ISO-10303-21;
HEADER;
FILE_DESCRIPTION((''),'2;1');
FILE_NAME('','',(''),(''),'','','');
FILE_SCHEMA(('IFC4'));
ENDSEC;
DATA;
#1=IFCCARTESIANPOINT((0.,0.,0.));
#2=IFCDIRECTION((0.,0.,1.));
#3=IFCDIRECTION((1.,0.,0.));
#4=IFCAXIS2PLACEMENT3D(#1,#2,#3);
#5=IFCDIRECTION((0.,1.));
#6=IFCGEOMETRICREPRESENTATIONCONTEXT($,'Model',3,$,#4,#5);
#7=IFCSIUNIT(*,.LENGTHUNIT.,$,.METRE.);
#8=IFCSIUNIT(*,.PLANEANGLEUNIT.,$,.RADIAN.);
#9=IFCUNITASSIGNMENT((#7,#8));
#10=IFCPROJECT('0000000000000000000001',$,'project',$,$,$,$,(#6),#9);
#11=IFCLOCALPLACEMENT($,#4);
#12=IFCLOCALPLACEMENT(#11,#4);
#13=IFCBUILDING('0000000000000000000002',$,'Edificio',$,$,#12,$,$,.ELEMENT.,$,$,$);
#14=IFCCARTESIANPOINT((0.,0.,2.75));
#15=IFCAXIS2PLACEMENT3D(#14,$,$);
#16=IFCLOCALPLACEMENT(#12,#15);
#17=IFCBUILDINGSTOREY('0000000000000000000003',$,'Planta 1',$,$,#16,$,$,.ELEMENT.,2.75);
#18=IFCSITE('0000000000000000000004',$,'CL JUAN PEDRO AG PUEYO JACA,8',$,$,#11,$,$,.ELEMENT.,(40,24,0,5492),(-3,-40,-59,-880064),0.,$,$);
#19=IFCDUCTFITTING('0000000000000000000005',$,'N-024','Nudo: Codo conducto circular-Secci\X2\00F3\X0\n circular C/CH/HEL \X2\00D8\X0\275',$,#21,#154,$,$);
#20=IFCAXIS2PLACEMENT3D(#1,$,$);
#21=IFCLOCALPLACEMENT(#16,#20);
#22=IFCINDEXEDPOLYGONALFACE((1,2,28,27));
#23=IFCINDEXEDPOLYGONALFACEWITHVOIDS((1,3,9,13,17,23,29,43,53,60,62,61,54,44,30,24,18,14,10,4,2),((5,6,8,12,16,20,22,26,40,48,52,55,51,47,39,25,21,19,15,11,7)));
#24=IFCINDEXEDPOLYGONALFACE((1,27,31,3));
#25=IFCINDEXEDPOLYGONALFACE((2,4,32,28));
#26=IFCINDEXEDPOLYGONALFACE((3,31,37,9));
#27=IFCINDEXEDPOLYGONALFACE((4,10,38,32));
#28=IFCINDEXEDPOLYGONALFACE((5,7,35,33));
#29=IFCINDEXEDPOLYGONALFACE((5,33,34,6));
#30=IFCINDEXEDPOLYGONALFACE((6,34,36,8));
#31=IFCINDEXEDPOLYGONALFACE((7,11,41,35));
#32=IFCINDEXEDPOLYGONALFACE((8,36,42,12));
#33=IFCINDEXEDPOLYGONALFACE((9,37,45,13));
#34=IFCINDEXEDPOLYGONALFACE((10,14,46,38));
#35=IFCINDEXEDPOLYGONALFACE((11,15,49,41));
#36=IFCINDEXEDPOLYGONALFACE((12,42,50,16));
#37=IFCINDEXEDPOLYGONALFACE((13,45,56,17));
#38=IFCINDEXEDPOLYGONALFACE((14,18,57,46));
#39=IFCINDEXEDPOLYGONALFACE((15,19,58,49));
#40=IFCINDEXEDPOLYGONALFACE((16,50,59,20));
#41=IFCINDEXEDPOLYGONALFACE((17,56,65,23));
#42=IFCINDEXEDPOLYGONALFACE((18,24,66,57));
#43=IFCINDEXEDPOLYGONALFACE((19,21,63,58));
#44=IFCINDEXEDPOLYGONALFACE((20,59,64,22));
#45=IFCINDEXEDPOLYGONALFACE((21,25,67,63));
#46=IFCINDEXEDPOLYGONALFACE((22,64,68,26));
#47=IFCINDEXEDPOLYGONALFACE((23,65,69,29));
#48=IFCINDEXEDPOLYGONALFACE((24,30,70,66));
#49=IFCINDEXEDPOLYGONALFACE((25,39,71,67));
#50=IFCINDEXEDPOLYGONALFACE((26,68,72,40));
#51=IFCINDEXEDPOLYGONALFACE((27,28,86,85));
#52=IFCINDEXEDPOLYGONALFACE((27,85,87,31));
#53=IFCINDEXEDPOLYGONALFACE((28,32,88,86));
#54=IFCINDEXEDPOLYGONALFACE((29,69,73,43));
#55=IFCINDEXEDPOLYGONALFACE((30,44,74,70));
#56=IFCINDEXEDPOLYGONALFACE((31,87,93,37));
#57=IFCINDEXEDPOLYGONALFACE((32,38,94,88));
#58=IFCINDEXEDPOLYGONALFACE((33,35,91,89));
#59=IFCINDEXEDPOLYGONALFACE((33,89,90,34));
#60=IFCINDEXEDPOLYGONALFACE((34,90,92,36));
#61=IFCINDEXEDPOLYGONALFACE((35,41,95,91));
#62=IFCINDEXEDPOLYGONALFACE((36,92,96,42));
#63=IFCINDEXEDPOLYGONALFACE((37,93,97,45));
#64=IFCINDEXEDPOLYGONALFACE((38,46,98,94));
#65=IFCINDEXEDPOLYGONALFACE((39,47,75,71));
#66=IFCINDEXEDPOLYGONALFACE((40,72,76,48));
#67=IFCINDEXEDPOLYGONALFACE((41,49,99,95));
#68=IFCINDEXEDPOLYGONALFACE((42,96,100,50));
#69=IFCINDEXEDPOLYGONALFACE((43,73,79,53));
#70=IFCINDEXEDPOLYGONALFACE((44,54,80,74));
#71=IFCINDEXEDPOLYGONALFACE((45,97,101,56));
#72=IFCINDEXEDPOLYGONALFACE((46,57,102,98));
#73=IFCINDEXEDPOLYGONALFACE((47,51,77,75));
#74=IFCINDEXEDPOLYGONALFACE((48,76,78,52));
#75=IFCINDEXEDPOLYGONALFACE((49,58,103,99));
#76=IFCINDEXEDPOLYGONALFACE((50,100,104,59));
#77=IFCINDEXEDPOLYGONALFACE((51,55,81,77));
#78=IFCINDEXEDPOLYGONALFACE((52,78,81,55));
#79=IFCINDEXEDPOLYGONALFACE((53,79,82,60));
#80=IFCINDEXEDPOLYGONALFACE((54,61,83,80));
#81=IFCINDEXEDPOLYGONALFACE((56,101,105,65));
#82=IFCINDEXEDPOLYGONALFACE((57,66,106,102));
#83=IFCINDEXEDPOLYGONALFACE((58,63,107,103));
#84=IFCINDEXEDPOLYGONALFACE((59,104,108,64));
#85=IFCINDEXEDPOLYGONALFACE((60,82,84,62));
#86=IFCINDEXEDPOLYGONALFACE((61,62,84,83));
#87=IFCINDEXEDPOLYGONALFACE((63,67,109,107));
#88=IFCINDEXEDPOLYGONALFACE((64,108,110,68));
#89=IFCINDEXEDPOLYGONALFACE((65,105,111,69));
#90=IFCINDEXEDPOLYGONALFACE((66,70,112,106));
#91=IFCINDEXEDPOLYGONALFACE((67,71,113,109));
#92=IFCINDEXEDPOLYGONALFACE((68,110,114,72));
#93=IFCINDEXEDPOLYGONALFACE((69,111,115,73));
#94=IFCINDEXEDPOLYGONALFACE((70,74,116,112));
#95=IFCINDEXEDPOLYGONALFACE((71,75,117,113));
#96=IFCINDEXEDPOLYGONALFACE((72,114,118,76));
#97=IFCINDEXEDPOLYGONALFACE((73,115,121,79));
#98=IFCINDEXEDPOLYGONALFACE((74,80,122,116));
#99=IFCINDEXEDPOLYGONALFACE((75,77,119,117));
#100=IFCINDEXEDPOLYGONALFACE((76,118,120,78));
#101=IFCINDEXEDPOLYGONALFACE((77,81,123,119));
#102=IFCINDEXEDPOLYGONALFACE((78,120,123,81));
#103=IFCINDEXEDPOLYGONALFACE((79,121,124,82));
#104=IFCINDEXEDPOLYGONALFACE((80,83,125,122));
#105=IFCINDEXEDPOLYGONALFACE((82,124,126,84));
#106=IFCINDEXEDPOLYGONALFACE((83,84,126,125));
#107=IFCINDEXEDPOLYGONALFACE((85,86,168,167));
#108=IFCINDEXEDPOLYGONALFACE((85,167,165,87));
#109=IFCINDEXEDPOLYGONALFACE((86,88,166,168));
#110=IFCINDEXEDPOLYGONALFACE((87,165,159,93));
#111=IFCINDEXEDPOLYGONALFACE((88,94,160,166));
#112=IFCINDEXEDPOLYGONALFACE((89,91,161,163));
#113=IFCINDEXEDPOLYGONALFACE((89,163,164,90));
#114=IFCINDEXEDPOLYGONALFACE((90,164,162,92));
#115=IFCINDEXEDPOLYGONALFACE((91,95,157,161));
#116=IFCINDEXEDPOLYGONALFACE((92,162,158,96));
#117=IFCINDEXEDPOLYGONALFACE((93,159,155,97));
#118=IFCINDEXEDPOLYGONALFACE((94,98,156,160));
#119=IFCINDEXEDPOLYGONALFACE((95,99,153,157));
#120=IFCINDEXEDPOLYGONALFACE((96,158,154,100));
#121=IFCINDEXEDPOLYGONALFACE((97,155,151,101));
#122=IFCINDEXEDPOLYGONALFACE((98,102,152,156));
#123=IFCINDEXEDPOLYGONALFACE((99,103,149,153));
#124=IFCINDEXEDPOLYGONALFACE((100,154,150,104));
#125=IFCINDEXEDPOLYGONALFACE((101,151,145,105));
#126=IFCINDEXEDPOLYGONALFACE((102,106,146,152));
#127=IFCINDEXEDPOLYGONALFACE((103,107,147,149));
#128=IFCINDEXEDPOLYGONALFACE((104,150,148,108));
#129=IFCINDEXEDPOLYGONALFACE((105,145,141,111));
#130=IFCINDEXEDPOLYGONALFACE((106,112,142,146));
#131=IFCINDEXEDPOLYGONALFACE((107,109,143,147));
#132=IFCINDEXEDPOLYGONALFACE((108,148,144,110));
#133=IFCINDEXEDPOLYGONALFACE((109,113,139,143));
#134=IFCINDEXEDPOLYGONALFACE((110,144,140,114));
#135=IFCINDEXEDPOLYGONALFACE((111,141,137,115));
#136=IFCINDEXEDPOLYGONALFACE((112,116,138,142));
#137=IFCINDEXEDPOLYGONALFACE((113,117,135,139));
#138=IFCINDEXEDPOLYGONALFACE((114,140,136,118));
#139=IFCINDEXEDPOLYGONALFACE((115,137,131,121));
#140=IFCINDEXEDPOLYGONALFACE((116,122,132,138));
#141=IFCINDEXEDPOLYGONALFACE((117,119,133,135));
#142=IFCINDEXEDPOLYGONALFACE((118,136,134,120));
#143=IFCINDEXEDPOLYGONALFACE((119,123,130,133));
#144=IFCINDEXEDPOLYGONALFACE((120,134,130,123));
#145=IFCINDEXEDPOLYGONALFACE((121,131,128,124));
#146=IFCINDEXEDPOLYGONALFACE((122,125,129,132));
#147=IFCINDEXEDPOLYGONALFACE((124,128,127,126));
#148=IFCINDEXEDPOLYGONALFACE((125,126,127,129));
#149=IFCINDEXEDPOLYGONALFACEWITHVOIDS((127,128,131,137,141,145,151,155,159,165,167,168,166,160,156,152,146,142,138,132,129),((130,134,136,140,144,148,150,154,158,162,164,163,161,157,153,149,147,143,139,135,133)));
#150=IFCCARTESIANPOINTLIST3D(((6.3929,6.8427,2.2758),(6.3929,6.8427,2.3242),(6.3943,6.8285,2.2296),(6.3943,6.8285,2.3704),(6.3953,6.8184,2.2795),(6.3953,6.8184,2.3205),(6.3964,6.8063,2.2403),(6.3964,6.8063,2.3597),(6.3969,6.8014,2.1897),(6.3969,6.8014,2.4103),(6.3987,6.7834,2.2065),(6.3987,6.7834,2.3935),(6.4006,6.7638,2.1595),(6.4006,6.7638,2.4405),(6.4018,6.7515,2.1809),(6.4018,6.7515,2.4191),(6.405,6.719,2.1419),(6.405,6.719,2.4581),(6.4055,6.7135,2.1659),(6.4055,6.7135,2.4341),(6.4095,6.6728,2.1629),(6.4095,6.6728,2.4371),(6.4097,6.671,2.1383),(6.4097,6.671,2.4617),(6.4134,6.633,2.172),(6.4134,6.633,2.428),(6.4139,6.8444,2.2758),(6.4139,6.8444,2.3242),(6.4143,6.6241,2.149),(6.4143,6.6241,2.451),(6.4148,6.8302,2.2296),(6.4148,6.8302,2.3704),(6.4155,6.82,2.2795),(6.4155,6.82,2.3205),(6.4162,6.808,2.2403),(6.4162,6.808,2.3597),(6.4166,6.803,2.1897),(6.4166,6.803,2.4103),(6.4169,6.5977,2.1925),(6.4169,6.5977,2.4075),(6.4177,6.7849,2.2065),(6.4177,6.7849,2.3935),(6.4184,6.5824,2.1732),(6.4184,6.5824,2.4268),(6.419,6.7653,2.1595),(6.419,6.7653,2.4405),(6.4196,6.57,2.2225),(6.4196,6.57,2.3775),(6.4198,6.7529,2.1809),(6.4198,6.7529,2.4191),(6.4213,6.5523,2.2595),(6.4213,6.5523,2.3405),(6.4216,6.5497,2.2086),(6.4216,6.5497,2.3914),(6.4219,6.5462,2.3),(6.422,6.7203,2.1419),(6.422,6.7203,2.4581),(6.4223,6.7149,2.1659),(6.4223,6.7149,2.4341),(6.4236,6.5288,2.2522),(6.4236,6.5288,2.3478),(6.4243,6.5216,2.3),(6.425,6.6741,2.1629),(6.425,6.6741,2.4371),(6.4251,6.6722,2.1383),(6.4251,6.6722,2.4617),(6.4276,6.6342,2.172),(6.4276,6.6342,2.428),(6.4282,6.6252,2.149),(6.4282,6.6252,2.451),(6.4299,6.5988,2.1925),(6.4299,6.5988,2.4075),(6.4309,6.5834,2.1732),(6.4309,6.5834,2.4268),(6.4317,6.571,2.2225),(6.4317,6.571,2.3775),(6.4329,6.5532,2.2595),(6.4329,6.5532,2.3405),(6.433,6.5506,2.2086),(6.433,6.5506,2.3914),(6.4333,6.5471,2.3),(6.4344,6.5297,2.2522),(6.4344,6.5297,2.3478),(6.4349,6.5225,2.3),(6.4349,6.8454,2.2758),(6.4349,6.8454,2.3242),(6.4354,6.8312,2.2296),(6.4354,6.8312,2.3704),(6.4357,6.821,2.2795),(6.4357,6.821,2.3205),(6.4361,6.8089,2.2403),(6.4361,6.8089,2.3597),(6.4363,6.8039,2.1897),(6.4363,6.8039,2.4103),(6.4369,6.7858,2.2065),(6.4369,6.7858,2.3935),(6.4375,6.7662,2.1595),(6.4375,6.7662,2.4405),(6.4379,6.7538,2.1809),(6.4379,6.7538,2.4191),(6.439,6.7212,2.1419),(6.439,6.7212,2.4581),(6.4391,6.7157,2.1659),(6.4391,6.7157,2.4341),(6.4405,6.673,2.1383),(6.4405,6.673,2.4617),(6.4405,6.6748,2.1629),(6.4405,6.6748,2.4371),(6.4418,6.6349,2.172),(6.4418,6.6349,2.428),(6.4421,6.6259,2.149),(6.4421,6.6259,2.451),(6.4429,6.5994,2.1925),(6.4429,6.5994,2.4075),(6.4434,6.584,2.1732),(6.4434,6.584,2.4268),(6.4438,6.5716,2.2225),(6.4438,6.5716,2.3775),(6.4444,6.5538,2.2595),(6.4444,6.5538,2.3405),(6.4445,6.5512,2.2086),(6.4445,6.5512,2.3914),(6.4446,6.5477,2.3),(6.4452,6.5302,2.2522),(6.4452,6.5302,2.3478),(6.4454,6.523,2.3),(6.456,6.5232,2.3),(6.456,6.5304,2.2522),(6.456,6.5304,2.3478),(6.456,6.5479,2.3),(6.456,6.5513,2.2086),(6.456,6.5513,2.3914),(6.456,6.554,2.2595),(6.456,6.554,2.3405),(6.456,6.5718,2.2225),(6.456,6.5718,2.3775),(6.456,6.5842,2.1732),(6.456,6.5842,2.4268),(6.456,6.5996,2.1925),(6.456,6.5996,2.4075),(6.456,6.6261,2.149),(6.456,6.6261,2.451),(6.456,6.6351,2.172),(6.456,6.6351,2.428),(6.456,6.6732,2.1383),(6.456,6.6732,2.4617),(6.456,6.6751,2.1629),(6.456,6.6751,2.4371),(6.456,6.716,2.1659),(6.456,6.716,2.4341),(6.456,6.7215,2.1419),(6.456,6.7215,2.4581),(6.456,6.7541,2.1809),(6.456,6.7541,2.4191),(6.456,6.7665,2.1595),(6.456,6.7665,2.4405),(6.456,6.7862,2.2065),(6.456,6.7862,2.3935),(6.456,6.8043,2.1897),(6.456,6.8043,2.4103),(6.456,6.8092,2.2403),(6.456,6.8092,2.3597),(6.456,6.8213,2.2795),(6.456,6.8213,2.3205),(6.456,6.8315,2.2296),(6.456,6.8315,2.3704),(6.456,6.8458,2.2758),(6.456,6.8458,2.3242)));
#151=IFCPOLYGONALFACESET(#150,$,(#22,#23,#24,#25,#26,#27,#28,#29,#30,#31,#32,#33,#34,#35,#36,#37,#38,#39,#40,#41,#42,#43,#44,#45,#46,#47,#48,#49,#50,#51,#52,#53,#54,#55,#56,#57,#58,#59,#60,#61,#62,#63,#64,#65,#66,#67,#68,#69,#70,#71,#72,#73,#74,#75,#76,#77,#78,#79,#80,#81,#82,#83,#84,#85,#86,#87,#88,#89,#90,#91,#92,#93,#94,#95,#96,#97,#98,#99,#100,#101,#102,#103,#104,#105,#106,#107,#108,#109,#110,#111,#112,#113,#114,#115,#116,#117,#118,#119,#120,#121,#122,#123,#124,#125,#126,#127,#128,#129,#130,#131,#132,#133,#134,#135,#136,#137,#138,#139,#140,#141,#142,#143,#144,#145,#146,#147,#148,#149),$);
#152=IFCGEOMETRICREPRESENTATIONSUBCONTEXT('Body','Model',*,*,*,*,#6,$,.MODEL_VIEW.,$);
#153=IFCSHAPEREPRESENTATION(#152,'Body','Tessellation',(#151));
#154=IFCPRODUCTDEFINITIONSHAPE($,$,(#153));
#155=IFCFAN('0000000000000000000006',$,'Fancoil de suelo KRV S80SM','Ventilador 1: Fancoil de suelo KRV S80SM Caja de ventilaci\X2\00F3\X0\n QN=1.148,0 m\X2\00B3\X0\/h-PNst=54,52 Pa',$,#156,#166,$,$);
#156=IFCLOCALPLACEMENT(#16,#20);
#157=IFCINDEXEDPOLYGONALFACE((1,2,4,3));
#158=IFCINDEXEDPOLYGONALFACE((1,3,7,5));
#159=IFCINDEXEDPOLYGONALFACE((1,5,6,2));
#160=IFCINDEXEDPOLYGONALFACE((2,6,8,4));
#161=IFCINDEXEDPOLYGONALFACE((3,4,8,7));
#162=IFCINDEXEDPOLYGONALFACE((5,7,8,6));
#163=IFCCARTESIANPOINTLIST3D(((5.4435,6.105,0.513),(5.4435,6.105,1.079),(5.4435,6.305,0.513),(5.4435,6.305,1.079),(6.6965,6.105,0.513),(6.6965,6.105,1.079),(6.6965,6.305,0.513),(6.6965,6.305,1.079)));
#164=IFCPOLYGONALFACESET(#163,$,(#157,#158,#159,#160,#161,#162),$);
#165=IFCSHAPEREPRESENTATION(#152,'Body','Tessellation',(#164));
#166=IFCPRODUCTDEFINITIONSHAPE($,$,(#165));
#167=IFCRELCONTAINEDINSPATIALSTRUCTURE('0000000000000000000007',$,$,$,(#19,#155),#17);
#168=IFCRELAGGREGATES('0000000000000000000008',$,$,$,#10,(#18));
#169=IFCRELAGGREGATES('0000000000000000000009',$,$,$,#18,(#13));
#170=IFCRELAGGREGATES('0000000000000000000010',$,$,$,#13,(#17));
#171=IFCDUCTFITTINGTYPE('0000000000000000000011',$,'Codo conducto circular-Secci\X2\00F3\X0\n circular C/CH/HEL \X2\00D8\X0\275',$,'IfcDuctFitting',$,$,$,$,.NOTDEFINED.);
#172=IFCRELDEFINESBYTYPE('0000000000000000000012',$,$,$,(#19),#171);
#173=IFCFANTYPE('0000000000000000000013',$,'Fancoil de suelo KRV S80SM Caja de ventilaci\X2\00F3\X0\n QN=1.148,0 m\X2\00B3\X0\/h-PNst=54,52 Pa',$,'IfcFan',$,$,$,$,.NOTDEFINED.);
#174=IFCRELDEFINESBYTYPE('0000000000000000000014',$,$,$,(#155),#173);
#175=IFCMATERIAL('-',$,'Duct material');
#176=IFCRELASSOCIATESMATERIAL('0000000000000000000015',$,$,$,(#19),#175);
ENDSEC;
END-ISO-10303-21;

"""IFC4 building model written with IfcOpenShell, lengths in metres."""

from ifc_helpers import new_model, entity, si_unit, direction, frame, origin_with_axes, place, context, subcontext, project, spatial, polyline, outline, extrude, source, transform, mapped, material, type_object, element, save


model = new_model("IFC4")

# Units and contexts
model_context = context("Model", 3, world=origin_with_axes(), true_north=direction((0.0, 1.0)))
body_context = subcontext(model_context, "Body", "Model", "MODEL_VIEW")
ifc_project = project(units=[si_unit("LENGTHUNIT", "METRE"), si_unit("PLANEANGLEUNIT", "RADIAN")], contexts=[model_context])

# Site, building, storey
site_placement = place(None, origin_with_axes())
site = spatial("IfcSite", under=ifc_project, at=site_placement, Name="CL JUAN PEDRO AG PUEYO JACA,8", CompositionType="ELEMENT", RefLatitude=(40, 24, 0, 5492), RefLongitude=(-3, -40, -59, -880064), RefElevation=0.0)
building_placement = place(site_placement, origin_with_axes())
building = spatial("IfcBuilding", under=site, at=building_placement, Name="Edificio", CompositionType="ELEMENT")
storey_placement = place(building_placement, frame((0.0, 0.0, 2.75)))
storey = spatial("IfcBuildingStorey", under=building, at=storey_placement, Name="Planta 1", CompositionType="ELEMENT", Elevation=2.75)

# Shared definitions
ifc_material_1 = material(Name="-", Category="Duct material")

# Duct fitting
duct_fitting_type_1 = type_object("IfcDuctFittingType", Name="Codo conducto circular-Sección circular C/CH/HEL Ø275", ApplicableOccurrence="IfcDuctFitting", PredefinedType="NOTDEFINED")
shared_shape_1 = source(origin_with_axes(), body_context, "Body", "SweptSolid", [
    entity("IfcRevolvedAreaSolid", entity("IfcCircleHollowProfileDef", "AREA", None, entity("IfcAxis2Placement2D", entity("IfcCartesianPoint", [0.0, 0.0]), entity("IfcDirection", [1.0, 0.0])), 0.1622, 0.0247), entity("IfcAxis2Placement3D", entity("IfcCartesianPoint", [0.0023, 0.0237, 0.0]), entity("IfcDirection", [-0.097553, -0.99523, 0.0]), entity("IfcDirection", [0.99523, -0.097553, 0.0])), entity("IfcAxis1Placement", entity("IfcCartesianPoint", [0.4866, 0.0, 0.0]), entity("IfcDirection", [0.0, 1.0, 0.0])), 0.097709),
])
duct_fitting_1_placement = place(storey_placement, origin_with_axes())
element("IfcDuctFitting", 1, at=duct_fitting_1_placement, inside=storey, type_object=duct_fitting_type_1, material=ifc_material_1, Name="N-024", Description="Nudo: Codo conducto circular-Sección circular C/CH/HEL Ø275", context=body_context, shape_type="MappedRepresentation", body=[
    mapped(shared_shape_1, transform((6.4322, 6.6854, 2.3), x_axis=(0.097553, -0.99523, 0.0), y_axis=(0.99523, 0.097553, 0.0), z_axis=(0.0, 0.0, 1.0), scale=1.0)),
])

# Fan
fan_type_1 = type_object("IfcFanType", Name="Fancoil de suelo KRV S80SM Caja de ventilación QN=1.148,0 m³/h-PNst=54,52 Pa", ApplicableOccurrence="IfcFan", PredefinedType="NOTDEFINED")
shared_shape_2 = source(origin_with_axes(), body_context, "Body", "SweptSolid", [
    extrude(outline(polyline([(0.0, -0.2), (0.0, 0.0), (-1.253, 0.0), (-1.253, -0.2), (0.0, -0.2)])), frame((0.0, 0.0, -0.566), z_axis=(0.0, 0.0, 1.0), x_axis=(1.0, 0.0, 0.0)), (0.0, 0.0, 1.0), 0.566),
])
fan_1_placement = place(storey_placement, origin_with_axes())
element("IfcFan", 2, at=fan_1_placement, inside=storey, type_object=fan_type_1, Name="Fancoil de suelo KRV S80SM", Description="Ventilador 1: Fancoil de suelo KRV S80SM Caja de ventilación QN=1.148,0 m³/h-PNst=54,52 Pa", context=body_context, shape_type="MappedRepresentation", body=[
    mapped(shared_shape_2, transform((6.6965, 6.305, 1.079), x_axis=(1.0, 0.0, 0.0), y_axis=(0.0, 1.0, 0.0), z_axis=(0.0, 0.0, 1.0), scale=1.0)),
])

save(model, "model.ifc")
